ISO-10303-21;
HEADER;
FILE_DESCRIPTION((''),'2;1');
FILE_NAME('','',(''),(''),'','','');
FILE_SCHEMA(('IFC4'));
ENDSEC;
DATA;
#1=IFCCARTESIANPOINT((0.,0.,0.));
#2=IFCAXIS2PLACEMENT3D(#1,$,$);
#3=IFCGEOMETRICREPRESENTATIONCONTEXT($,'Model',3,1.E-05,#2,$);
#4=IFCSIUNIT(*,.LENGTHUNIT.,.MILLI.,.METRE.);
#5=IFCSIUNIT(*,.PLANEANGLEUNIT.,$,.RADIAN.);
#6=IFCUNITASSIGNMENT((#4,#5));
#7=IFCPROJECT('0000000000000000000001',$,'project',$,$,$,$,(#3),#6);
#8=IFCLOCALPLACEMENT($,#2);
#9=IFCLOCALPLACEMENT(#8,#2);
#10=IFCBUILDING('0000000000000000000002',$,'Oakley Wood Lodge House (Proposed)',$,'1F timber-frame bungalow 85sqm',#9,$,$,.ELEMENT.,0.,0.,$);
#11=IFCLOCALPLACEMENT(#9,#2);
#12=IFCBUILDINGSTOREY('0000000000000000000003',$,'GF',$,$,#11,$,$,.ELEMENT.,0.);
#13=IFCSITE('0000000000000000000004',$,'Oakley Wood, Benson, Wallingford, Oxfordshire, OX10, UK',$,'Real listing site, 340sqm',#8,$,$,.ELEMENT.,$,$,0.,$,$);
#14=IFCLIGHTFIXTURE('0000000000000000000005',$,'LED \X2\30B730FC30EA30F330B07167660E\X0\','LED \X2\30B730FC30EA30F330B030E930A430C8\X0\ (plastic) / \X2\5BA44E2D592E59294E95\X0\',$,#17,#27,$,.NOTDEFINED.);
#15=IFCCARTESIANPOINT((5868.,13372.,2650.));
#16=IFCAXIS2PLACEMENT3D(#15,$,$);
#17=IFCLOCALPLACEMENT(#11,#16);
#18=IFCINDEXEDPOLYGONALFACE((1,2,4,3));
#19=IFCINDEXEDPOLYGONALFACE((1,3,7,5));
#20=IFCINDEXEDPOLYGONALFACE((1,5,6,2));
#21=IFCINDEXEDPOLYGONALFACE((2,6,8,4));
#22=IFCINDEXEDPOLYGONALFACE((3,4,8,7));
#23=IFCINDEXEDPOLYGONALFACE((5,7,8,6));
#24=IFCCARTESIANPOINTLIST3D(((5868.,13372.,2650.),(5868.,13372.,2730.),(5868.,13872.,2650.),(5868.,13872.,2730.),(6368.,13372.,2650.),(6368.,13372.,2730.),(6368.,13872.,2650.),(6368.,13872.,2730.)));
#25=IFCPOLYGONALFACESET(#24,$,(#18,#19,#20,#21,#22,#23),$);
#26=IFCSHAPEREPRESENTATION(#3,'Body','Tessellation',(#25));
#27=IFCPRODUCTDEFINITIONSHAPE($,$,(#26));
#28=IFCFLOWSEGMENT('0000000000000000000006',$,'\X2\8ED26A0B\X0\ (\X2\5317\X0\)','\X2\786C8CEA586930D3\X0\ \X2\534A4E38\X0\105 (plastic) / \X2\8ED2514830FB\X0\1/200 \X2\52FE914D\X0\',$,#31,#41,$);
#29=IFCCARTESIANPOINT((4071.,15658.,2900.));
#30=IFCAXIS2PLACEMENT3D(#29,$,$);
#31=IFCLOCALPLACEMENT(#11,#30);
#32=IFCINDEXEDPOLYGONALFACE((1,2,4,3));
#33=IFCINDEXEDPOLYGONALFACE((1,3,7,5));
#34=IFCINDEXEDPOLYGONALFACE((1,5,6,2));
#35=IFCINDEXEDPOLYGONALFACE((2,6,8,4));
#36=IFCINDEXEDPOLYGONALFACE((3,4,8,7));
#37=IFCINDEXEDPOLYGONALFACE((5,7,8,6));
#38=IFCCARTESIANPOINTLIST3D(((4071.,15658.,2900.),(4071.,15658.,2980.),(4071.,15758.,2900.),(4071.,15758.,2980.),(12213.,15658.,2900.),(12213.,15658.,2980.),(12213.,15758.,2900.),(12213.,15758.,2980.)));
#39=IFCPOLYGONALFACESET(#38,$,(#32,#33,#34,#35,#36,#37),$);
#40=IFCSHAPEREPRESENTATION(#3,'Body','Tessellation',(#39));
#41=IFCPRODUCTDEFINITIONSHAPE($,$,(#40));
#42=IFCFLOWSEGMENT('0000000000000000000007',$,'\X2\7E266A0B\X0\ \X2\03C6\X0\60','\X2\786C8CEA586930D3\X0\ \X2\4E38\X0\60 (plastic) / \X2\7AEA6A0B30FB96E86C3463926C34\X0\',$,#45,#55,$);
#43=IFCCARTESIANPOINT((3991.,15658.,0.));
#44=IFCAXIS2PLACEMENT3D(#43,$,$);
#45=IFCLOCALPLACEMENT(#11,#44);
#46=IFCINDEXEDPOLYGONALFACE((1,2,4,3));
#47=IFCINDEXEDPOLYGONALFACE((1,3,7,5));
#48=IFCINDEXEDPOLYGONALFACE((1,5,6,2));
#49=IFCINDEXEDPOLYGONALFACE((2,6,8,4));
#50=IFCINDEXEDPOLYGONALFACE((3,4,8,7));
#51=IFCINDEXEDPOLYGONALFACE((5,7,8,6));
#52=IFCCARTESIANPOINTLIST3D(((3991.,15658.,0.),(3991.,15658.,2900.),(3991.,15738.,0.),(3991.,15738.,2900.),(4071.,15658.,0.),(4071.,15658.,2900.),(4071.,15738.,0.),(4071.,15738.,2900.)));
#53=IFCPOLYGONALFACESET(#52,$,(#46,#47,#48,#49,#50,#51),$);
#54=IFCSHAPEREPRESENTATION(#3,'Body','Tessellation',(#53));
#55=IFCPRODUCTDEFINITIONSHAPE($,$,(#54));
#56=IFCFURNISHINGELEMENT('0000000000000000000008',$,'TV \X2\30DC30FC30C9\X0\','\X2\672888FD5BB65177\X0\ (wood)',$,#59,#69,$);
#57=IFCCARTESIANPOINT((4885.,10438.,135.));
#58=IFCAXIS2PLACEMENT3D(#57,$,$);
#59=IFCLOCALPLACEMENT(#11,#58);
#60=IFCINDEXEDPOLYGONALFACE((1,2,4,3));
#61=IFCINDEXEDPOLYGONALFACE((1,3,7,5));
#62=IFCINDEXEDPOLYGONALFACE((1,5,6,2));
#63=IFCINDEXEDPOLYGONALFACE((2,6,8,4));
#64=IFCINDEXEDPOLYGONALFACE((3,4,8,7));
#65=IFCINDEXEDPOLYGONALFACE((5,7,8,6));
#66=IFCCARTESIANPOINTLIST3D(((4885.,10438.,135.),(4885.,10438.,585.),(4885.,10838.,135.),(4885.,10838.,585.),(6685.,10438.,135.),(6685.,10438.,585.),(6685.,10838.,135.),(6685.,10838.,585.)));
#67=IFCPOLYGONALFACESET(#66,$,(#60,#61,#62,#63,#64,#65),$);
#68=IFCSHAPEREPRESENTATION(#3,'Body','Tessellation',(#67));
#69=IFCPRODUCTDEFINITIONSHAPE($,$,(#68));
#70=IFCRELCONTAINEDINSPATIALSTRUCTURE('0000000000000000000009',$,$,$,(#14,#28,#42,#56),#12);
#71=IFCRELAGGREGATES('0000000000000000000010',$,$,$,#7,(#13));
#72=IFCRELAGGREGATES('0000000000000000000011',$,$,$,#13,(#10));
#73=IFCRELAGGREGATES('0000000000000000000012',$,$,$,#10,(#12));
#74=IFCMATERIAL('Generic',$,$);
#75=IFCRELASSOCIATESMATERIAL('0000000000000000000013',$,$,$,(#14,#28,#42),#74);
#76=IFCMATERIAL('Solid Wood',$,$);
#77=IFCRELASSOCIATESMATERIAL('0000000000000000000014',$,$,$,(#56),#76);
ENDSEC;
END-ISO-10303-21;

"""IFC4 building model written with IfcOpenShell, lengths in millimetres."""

from ifc_helpers import new_model, si_unit, frame, frame_2d, origin, place, context, project, spatial, rectangle, extrude, material, element, save


model = new_model("IFC4")

# Units and contexts
model_context = context("Model", 3, precision=1e-05, world=origin())
ifc_project = project(units=[si_unit("LENGTHUNIT", "METRE", prefix="MILLI"), si_unit("PLANEANGLEUNIT", "RADIAN")], contexts=[model_context])

# Site, building, storey
site_placement = place(None, origin())
site = spatial("IfcSite", under=ifc_project, at=site_placement, Name="Oakley Wood, Benson, Wallingford, Oxfordshire, OX10, UK", ObjectType="Real listing site, 340sqm", CompositionType="ELEMENT", RefElevation=0.0)
building_placement = place(site_placement, origin())
building = spatial("IfcBuilding", under=site, at=building_placement, Name="Oakley Wood Lodge House (Proposed)", ObjectType="1F timber-frame bungalow 85sqm", CompositionType="ELEMENT", ElevationOfRefHeight=0.0, ElevationOfTerrain=0.0)
storey_placement = place(building_placement, origin())
storey = spatial("IfcBuildingStorey", under=building, at=storey_placement, Name="GF", CompositionType="ELEMENT", Elevation=0.0)

# Shared definitions
ifc_material_1 = material(Name="Solid Wood")

# Shared definitions
ifc_material_2 = material(Name="Generic")

# Light fixture
light_fixture_placement = place(storey_placement, frame((5868.0, 13372.0, 2650.0)))
element("IfcLightFixture", 1, at=light_fixture_placement, inside=storey, material=ifc_material_2, Name="LED シーリング照明", Description="LED シーリングライト (plastic) / 室中央天井", PredefinedType="NOTDEFINED", context=model_context, shape_type="SweptSolid", body=[
    extrude(rectangle(XDim=500.0, YDim=500.0, at=frame_2d((250.0, 250.0))), frame((5868.0, 13372.0, 2650.0)), (0.0, 0.0, 1.0), 80.0),
])

# Flow segments
flow_segment_1_placement = place(storey_placement, frame((4071.0, 15658.0, 2900.0)))
element("IfcFlowSegment", 2, at=flow_segment_1_placement, inside=storey, material=ifc_material_2, Name="軒樋 (北)", Description="硬質塩ビ 半丸105 (plastic) / 軒先・1/200 勾配", context=model_context, shape_type="SweptSolid", body=[
    extrude(rectangle(XDim=8142.0, YDim=100.0, at=frame_2d((4071.0, 50.0))), frame((4071.0, 15658.0, 2900.0)), (0.0, 0.0, 1.0), 80.0),
])
flow_segment_2_placement = place(storey_placement, frame((3991.0, 15658.0, 0.0)))
element("IfcFlowSegment", 3, at=flow_segment_2_placement, inside=storey, material=ifc_material_2, Name="縦樋 φ60", Description="硬質塩ビ 丸60 (plastic) / 竪樋・雨水排水", context=model_context, shape_type="SweptSolid", body=[
    extrude(rectangle(XDim=80.0, YDim=80.0, at=frame_2d((40.0, 40.0))), frame((3991.0, 15658.0, 0.0)), (0.0, 0.0, 1.0), 2900.0),
])

# Furnishing element
furnishing_placement = place(storey_placement, frame((4885.0, 10438.0, 135.0)))
element("IfcFurnishingElement", 4, at=furnishing_placement, inside=storey, material=ifc_material_1, Name="TV ボード", Description="木製家具 (wood)", context=model_context, shape_type="SweptSolid", body=[
    extrude(rectangle(XDim=1800.0, YDim=400.0, at=frame_2d((900.0, 200.0))), frame((4885.0, 10438.0, 135.0)), (0.0, 0.0, 1.0), 450.0),
])

save(model, "model.ifc")
